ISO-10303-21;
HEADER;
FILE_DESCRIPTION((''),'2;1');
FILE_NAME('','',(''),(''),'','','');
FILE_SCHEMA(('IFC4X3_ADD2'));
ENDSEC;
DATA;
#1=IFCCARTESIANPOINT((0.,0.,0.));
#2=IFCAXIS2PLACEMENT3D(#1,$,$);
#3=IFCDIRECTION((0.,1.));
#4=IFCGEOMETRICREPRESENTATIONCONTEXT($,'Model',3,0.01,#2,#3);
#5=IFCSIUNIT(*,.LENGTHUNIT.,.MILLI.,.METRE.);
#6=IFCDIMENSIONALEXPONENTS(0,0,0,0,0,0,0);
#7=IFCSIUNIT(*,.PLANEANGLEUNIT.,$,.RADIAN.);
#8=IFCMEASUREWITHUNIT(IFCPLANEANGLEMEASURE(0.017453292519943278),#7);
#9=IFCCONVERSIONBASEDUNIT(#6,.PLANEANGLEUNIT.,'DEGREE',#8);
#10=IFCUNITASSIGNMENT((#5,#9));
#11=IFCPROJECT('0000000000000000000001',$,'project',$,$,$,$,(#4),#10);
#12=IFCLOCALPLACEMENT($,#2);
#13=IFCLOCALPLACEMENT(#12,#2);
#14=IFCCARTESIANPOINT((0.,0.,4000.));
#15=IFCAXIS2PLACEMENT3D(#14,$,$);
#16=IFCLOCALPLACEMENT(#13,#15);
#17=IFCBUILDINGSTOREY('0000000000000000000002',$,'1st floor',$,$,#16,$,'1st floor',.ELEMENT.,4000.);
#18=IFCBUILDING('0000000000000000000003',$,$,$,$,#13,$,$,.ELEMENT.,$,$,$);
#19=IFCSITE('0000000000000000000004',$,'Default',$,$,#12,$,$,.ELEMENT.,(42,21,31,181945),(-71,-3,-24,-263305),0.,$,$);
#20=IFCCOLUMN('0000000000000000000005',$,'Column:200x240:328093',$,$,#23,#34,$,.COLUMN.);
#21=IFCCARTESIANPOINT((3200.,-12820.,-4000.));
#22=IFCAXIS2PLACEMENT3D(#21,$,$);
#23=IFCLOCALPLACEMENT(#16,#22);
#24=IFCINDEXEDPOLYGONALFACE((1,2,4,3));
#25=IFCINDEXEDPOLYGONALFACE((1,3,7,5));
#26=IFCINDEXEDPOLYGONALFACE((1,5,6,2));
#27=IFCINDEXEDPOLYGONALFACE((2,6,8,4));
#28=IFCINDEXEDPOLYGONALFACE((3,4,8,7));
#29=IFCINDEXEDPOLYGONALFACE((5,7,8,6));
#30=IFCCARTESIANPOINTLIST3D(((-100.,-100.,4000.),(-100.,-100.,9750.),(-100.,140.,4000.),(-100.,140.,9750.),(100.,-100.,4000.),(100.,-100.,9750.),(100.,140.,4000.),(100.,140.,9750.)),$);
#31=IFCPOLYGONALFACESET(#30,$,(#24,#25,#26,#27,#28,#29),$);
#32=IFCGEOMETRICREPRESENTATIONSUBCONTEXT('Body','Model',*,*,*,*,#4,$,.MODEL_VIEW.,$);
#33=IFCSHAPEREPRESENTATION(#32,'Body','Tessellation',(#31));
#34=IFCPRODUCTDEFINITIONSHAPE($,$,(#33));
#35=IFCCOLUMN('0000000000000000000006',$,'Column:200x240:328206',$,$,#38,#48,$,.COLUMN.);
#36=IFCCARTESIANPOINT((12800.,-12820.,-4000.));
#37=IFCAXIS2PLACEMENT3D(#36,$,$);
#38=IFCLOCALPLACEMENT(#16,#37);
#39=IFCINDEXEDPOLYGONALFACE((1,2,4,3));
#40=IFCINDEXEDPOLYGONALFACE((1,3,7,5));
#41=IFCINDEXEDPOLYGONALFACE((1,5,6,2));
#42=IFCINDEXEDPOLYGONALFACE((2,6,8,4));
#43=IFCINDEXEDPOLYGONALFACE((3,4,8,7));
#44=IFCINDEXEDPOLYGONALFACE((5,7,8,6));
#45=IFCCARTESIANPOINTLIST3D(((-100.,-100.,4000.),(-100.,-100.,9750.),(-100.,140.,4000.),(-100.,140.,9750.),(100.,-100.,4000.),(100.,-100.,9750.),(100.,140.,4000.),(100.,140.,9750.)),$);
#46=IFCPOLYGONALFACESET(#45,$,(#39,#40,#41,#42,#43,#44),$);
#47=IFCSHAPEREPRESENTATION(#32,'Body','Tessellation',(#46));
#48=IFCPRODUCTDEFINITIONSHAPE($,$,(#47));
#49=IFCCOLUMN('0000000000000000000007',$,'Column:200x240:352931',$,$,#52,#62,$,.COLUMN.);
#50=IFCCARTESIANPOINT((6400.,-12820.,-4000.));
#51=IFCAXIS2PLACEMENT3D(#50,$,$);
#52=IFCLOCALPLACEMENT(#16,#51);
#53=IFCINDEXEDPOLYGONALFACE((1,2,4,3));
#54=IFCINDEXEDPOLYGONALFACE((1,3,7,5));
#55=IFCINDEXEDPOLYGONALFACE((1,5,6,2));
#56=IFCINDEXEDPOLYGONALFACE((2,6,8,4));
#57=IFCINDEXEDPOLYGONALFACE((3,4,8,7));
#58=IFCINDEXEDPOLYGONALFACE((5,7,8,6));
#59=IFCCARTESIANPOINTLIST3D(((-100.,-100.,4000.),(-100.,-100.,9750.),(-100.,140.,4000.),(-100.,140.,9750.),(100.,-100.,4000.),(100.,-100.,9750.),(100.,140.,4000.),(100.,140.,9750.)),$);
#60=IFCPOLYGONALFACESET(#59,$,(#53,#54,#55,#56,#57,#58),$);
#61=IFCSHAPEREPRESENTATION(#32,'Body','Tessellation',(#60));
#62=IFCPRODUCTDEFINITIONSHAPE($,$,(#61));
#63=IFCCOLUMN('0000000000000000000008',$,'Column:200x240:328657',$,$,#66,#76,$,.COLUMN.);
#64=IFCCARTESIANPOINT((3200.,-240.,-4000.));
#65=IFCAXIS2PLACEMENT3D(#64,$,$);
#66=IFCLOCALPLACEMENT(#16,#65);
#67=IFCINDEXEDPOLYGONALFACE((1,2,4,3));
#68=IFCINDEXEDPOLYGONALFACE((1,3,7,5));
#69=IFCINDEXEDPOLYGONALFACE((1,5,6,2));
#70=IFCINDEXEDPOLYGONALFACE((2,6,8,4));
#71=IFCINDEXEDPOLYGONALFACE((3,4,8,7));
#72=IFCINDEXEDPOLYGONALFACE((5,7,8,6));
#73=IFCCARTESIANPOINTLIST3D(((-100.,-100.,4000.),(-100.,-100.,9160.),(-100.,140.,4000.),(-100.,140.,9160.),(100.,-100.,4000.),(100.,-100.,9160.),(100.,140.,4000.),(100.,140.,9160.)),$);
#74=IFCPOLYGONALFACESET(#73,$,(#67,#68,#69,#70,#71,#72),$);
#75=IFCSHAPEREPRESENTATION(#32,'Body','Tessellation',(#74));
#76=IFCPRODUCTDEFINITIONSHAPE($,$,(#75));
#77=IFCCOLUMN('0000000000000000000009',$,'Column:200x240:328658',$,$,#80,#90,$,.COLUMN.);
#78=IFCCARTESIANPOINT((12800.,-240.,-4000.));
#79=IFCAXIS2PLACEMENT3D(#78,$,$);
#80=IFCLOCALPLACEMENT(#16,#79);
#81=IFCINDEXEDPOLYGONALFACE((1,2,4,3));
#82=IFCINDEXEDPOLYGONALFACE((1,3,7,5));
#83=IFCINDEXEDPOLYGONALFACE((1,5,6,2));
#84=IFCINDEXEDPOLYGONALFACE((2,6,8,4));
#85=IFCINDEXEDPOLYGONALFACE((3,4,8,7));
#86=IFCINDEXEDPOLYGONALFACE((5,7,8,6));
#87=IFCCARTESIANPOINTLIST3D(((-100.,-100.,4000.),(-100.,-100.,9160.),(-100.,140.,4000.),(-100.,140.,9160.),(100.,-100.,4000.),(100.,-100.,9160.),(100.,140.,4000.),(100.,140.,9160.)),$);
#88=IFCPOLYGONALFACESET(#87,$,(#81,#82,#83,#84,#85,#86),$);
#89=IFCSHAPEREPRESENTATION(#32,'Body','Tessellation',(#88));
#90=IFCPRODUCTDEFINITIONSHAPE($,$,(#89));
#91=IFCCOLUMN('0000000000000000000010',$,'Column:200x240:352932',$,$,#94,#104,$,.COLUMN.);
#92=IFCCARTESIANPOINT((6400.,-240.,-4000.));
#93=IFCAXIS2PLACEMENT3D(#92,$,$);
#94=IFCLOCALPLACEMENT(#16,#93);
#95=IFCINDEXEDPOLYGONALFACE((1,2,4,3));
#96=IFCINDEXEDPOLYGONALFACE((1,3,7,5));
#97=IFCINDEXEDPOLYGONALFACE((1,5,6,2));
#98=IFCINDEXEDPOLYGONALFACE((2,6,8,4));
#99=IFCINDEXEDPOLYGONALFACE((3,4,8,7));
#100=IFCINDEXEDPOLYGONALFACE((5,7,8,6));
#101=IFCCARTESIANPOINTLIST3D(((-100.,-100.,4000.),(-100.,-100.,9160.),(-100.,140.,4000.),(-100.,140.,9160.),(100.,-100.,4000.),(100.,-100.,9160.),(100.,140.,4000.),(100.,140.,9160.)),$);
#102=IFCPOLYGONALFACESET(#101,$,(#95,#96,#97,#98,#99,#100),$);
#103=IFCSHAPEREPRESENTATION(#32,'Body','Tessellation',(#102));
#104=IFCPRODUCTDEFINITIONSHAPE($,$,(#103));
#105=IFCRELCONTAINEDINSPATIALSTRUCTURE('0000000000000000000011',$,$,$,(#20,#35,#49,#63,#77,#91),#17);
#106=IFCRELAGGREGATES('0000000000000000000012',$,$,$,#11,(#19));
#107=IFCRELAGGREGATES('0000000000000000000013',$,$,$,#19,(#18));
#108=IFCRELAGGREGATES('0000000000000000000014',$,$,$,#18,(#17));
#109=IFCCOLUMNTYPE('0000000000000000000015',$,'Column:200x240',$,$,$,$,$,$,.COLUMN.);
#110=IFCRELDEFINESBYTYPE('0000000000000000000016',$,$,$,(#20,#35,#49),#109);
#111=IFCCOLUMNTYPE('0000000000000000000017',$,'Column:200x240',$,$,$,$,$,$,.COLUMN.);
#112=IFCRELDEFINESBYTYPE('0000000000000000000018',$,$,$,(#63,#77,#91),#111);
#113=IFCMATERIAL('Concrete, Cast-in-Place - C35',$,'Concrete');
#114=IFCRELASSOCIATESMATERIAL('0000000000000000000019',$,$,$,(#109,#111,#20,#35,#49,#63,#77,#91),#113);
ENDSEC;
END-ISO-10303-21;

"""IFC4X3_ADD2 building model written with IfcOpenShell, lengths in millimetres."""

from ifc_helpers import new_model, entity, si_unit, converted_unit, direction, frame, origin, origin_2d_with_axis, place, context, subcontext, project, spatial, rectangle, extrude, source, transform, mapped, material, material_profile, profile_set, profile_usage, type_object, type_shapes, element, save


model = new_model("IFC4X3_ADD2")

# Units and contexts
model_context = context("Model", 3, precision=0.01, world=origin(), true_north=direction((0.0, 1.0)))
body_context = subcontext(model_context, "Body", "Model", "MODEL_VIEW")
ifc_project = project(units=[si_unit("LENGTHUNIT", "METRE", prefix="MILLI"), converted_unit("PLANEANGLEUNIT", "DEGREE", entity("IfcPlaneAngleMeasure", 0.017453292519943278), si_unit("PLANEANGLEUNIT", "RADIAN"), dimensions=[0, 0, 0, 0, 0, 0, 0])], contexts=[model_context])

# Site, building, storey
site_placement = place(None, origin())
site = spatial("IfcSite", under=ifc_project, at=site_placement, Name="Default", CompositionType="ELEMENT", RefLatitude=(42, 21, 31, 181945), RefLongitude=(-71, -3, -24, -263305), RefElevation=0.0)
building_placement = place(site_placement, origin())
building = spatial("IfcBuilding", under=site, at=building_placement, CompositionType="ELEMENT")
storey_placement = place(building_placement, frame((0.0, 0.0, 4000.0)))
storey = spatial("IfcBuildingStorey", under=building, at=storey_placement, Name="1st floor", LongName="1st floor", CompositionType="ELEMENT", Elevation=4000.0)

# Columns
ifc_material_1 = material(Name="Concrete, Cast-in-Place - C35", Category="Concrete")
ifc_material_profile_1 = material_profile(ifc_material_1, rectangle(XDim=200.0, YDim=240.0, at=origin_2d_with_axis()), Name="200x240")
ifc_profile_set_1 = profile_set([ifc_material_profile_1], Name="200x240")
ifc_profile_usage_1 = profile_usage(ifc_profile_set_1)
column_type_1 = type_object("IfcColumnType", Name="Column:200x240", PredefinedType="COLUMN", material=ifc_profile_set_1)
shared_shape_1 = source(origin(), body_context, "Body", "SweptSolid", [
    extrude(rectangle(XDim=200.0, YDim=240.0, at=origin_2d_with_axis()), frame((0.0, 20.0, 4000.0), z_axis=(0.0, 0.0, 1.0), x_axis=(-1.0, 0.0, 0.0)), (0.0, 0.0, 1.0), 5750.0),
])
type_shapes(column_type_1, [shared_shape_1])
for number, where, name in (
    (1, (3200.0, -12820.0, -4000.0), "Column:200x240:328093"),
    (2, (12800.0, -12820.0, -4000.0), "Column:200x240:328206"),
    (3, (6400.0, -12820.0, -4000.0), "Column:200x240:352931"),
):
    element("IfcColumn", number, at=place(storey_placement, frame(where)), inside=storey, type_object=column_type_1, material=ifc_profile_usage_1, Name=name, PredefinedType="COLUMN", context=body_context, shape_type="MappedRepresentation", body=[
        mapped(shared_shape_1, transform((0.0, 0.0, 0.0), scale=1.0)),
    ])
column_type_2 = type_object("IfcColumnType", Name="Column:200x240", PredefinedType="COLUMN", material=ifc_profile_set_1)
shared_shape_2 = source(origin(), body_context, "Body", "SweptSolid", [
    extrude(rectangle(XDim=200.0, YDim=240.0, at=origin_2d_with_axis()), frame((0.0, 20.0, 4000.0), z_axis=(0.0, 0.0, 1.0), x_axis=(-1.0, 0.0, 0.0)), (0.0, 0.0, 1.0), 5160.0),
])
type_shapes(column_type_2, [shared_shape_2])
for number, where, name in (
    (4, (3200.0, -240.0, -4000.0), "Column:200x240:328657"),
    (5, (12800.0, -240.0, -4000.0), "Column:200x240:328658"),
    (6, (6400.0, -240.0, -4000.0), "Column:200x240:352932"),
):
    element("IfcColumn", number, at=place(storey_placement, frame(where)), inside=storey, type_object=column_type_2, material=ifc_profile_usage_1, Name=name, PredefinedType="COLUMN", context=body_context, shape_type="MappedRepresentation", body=[
        mapped(shared_shape_2, transform((0.0, 0.0, 0.0), scale=1.0)),
    ])

save(model, "model.ifc")
